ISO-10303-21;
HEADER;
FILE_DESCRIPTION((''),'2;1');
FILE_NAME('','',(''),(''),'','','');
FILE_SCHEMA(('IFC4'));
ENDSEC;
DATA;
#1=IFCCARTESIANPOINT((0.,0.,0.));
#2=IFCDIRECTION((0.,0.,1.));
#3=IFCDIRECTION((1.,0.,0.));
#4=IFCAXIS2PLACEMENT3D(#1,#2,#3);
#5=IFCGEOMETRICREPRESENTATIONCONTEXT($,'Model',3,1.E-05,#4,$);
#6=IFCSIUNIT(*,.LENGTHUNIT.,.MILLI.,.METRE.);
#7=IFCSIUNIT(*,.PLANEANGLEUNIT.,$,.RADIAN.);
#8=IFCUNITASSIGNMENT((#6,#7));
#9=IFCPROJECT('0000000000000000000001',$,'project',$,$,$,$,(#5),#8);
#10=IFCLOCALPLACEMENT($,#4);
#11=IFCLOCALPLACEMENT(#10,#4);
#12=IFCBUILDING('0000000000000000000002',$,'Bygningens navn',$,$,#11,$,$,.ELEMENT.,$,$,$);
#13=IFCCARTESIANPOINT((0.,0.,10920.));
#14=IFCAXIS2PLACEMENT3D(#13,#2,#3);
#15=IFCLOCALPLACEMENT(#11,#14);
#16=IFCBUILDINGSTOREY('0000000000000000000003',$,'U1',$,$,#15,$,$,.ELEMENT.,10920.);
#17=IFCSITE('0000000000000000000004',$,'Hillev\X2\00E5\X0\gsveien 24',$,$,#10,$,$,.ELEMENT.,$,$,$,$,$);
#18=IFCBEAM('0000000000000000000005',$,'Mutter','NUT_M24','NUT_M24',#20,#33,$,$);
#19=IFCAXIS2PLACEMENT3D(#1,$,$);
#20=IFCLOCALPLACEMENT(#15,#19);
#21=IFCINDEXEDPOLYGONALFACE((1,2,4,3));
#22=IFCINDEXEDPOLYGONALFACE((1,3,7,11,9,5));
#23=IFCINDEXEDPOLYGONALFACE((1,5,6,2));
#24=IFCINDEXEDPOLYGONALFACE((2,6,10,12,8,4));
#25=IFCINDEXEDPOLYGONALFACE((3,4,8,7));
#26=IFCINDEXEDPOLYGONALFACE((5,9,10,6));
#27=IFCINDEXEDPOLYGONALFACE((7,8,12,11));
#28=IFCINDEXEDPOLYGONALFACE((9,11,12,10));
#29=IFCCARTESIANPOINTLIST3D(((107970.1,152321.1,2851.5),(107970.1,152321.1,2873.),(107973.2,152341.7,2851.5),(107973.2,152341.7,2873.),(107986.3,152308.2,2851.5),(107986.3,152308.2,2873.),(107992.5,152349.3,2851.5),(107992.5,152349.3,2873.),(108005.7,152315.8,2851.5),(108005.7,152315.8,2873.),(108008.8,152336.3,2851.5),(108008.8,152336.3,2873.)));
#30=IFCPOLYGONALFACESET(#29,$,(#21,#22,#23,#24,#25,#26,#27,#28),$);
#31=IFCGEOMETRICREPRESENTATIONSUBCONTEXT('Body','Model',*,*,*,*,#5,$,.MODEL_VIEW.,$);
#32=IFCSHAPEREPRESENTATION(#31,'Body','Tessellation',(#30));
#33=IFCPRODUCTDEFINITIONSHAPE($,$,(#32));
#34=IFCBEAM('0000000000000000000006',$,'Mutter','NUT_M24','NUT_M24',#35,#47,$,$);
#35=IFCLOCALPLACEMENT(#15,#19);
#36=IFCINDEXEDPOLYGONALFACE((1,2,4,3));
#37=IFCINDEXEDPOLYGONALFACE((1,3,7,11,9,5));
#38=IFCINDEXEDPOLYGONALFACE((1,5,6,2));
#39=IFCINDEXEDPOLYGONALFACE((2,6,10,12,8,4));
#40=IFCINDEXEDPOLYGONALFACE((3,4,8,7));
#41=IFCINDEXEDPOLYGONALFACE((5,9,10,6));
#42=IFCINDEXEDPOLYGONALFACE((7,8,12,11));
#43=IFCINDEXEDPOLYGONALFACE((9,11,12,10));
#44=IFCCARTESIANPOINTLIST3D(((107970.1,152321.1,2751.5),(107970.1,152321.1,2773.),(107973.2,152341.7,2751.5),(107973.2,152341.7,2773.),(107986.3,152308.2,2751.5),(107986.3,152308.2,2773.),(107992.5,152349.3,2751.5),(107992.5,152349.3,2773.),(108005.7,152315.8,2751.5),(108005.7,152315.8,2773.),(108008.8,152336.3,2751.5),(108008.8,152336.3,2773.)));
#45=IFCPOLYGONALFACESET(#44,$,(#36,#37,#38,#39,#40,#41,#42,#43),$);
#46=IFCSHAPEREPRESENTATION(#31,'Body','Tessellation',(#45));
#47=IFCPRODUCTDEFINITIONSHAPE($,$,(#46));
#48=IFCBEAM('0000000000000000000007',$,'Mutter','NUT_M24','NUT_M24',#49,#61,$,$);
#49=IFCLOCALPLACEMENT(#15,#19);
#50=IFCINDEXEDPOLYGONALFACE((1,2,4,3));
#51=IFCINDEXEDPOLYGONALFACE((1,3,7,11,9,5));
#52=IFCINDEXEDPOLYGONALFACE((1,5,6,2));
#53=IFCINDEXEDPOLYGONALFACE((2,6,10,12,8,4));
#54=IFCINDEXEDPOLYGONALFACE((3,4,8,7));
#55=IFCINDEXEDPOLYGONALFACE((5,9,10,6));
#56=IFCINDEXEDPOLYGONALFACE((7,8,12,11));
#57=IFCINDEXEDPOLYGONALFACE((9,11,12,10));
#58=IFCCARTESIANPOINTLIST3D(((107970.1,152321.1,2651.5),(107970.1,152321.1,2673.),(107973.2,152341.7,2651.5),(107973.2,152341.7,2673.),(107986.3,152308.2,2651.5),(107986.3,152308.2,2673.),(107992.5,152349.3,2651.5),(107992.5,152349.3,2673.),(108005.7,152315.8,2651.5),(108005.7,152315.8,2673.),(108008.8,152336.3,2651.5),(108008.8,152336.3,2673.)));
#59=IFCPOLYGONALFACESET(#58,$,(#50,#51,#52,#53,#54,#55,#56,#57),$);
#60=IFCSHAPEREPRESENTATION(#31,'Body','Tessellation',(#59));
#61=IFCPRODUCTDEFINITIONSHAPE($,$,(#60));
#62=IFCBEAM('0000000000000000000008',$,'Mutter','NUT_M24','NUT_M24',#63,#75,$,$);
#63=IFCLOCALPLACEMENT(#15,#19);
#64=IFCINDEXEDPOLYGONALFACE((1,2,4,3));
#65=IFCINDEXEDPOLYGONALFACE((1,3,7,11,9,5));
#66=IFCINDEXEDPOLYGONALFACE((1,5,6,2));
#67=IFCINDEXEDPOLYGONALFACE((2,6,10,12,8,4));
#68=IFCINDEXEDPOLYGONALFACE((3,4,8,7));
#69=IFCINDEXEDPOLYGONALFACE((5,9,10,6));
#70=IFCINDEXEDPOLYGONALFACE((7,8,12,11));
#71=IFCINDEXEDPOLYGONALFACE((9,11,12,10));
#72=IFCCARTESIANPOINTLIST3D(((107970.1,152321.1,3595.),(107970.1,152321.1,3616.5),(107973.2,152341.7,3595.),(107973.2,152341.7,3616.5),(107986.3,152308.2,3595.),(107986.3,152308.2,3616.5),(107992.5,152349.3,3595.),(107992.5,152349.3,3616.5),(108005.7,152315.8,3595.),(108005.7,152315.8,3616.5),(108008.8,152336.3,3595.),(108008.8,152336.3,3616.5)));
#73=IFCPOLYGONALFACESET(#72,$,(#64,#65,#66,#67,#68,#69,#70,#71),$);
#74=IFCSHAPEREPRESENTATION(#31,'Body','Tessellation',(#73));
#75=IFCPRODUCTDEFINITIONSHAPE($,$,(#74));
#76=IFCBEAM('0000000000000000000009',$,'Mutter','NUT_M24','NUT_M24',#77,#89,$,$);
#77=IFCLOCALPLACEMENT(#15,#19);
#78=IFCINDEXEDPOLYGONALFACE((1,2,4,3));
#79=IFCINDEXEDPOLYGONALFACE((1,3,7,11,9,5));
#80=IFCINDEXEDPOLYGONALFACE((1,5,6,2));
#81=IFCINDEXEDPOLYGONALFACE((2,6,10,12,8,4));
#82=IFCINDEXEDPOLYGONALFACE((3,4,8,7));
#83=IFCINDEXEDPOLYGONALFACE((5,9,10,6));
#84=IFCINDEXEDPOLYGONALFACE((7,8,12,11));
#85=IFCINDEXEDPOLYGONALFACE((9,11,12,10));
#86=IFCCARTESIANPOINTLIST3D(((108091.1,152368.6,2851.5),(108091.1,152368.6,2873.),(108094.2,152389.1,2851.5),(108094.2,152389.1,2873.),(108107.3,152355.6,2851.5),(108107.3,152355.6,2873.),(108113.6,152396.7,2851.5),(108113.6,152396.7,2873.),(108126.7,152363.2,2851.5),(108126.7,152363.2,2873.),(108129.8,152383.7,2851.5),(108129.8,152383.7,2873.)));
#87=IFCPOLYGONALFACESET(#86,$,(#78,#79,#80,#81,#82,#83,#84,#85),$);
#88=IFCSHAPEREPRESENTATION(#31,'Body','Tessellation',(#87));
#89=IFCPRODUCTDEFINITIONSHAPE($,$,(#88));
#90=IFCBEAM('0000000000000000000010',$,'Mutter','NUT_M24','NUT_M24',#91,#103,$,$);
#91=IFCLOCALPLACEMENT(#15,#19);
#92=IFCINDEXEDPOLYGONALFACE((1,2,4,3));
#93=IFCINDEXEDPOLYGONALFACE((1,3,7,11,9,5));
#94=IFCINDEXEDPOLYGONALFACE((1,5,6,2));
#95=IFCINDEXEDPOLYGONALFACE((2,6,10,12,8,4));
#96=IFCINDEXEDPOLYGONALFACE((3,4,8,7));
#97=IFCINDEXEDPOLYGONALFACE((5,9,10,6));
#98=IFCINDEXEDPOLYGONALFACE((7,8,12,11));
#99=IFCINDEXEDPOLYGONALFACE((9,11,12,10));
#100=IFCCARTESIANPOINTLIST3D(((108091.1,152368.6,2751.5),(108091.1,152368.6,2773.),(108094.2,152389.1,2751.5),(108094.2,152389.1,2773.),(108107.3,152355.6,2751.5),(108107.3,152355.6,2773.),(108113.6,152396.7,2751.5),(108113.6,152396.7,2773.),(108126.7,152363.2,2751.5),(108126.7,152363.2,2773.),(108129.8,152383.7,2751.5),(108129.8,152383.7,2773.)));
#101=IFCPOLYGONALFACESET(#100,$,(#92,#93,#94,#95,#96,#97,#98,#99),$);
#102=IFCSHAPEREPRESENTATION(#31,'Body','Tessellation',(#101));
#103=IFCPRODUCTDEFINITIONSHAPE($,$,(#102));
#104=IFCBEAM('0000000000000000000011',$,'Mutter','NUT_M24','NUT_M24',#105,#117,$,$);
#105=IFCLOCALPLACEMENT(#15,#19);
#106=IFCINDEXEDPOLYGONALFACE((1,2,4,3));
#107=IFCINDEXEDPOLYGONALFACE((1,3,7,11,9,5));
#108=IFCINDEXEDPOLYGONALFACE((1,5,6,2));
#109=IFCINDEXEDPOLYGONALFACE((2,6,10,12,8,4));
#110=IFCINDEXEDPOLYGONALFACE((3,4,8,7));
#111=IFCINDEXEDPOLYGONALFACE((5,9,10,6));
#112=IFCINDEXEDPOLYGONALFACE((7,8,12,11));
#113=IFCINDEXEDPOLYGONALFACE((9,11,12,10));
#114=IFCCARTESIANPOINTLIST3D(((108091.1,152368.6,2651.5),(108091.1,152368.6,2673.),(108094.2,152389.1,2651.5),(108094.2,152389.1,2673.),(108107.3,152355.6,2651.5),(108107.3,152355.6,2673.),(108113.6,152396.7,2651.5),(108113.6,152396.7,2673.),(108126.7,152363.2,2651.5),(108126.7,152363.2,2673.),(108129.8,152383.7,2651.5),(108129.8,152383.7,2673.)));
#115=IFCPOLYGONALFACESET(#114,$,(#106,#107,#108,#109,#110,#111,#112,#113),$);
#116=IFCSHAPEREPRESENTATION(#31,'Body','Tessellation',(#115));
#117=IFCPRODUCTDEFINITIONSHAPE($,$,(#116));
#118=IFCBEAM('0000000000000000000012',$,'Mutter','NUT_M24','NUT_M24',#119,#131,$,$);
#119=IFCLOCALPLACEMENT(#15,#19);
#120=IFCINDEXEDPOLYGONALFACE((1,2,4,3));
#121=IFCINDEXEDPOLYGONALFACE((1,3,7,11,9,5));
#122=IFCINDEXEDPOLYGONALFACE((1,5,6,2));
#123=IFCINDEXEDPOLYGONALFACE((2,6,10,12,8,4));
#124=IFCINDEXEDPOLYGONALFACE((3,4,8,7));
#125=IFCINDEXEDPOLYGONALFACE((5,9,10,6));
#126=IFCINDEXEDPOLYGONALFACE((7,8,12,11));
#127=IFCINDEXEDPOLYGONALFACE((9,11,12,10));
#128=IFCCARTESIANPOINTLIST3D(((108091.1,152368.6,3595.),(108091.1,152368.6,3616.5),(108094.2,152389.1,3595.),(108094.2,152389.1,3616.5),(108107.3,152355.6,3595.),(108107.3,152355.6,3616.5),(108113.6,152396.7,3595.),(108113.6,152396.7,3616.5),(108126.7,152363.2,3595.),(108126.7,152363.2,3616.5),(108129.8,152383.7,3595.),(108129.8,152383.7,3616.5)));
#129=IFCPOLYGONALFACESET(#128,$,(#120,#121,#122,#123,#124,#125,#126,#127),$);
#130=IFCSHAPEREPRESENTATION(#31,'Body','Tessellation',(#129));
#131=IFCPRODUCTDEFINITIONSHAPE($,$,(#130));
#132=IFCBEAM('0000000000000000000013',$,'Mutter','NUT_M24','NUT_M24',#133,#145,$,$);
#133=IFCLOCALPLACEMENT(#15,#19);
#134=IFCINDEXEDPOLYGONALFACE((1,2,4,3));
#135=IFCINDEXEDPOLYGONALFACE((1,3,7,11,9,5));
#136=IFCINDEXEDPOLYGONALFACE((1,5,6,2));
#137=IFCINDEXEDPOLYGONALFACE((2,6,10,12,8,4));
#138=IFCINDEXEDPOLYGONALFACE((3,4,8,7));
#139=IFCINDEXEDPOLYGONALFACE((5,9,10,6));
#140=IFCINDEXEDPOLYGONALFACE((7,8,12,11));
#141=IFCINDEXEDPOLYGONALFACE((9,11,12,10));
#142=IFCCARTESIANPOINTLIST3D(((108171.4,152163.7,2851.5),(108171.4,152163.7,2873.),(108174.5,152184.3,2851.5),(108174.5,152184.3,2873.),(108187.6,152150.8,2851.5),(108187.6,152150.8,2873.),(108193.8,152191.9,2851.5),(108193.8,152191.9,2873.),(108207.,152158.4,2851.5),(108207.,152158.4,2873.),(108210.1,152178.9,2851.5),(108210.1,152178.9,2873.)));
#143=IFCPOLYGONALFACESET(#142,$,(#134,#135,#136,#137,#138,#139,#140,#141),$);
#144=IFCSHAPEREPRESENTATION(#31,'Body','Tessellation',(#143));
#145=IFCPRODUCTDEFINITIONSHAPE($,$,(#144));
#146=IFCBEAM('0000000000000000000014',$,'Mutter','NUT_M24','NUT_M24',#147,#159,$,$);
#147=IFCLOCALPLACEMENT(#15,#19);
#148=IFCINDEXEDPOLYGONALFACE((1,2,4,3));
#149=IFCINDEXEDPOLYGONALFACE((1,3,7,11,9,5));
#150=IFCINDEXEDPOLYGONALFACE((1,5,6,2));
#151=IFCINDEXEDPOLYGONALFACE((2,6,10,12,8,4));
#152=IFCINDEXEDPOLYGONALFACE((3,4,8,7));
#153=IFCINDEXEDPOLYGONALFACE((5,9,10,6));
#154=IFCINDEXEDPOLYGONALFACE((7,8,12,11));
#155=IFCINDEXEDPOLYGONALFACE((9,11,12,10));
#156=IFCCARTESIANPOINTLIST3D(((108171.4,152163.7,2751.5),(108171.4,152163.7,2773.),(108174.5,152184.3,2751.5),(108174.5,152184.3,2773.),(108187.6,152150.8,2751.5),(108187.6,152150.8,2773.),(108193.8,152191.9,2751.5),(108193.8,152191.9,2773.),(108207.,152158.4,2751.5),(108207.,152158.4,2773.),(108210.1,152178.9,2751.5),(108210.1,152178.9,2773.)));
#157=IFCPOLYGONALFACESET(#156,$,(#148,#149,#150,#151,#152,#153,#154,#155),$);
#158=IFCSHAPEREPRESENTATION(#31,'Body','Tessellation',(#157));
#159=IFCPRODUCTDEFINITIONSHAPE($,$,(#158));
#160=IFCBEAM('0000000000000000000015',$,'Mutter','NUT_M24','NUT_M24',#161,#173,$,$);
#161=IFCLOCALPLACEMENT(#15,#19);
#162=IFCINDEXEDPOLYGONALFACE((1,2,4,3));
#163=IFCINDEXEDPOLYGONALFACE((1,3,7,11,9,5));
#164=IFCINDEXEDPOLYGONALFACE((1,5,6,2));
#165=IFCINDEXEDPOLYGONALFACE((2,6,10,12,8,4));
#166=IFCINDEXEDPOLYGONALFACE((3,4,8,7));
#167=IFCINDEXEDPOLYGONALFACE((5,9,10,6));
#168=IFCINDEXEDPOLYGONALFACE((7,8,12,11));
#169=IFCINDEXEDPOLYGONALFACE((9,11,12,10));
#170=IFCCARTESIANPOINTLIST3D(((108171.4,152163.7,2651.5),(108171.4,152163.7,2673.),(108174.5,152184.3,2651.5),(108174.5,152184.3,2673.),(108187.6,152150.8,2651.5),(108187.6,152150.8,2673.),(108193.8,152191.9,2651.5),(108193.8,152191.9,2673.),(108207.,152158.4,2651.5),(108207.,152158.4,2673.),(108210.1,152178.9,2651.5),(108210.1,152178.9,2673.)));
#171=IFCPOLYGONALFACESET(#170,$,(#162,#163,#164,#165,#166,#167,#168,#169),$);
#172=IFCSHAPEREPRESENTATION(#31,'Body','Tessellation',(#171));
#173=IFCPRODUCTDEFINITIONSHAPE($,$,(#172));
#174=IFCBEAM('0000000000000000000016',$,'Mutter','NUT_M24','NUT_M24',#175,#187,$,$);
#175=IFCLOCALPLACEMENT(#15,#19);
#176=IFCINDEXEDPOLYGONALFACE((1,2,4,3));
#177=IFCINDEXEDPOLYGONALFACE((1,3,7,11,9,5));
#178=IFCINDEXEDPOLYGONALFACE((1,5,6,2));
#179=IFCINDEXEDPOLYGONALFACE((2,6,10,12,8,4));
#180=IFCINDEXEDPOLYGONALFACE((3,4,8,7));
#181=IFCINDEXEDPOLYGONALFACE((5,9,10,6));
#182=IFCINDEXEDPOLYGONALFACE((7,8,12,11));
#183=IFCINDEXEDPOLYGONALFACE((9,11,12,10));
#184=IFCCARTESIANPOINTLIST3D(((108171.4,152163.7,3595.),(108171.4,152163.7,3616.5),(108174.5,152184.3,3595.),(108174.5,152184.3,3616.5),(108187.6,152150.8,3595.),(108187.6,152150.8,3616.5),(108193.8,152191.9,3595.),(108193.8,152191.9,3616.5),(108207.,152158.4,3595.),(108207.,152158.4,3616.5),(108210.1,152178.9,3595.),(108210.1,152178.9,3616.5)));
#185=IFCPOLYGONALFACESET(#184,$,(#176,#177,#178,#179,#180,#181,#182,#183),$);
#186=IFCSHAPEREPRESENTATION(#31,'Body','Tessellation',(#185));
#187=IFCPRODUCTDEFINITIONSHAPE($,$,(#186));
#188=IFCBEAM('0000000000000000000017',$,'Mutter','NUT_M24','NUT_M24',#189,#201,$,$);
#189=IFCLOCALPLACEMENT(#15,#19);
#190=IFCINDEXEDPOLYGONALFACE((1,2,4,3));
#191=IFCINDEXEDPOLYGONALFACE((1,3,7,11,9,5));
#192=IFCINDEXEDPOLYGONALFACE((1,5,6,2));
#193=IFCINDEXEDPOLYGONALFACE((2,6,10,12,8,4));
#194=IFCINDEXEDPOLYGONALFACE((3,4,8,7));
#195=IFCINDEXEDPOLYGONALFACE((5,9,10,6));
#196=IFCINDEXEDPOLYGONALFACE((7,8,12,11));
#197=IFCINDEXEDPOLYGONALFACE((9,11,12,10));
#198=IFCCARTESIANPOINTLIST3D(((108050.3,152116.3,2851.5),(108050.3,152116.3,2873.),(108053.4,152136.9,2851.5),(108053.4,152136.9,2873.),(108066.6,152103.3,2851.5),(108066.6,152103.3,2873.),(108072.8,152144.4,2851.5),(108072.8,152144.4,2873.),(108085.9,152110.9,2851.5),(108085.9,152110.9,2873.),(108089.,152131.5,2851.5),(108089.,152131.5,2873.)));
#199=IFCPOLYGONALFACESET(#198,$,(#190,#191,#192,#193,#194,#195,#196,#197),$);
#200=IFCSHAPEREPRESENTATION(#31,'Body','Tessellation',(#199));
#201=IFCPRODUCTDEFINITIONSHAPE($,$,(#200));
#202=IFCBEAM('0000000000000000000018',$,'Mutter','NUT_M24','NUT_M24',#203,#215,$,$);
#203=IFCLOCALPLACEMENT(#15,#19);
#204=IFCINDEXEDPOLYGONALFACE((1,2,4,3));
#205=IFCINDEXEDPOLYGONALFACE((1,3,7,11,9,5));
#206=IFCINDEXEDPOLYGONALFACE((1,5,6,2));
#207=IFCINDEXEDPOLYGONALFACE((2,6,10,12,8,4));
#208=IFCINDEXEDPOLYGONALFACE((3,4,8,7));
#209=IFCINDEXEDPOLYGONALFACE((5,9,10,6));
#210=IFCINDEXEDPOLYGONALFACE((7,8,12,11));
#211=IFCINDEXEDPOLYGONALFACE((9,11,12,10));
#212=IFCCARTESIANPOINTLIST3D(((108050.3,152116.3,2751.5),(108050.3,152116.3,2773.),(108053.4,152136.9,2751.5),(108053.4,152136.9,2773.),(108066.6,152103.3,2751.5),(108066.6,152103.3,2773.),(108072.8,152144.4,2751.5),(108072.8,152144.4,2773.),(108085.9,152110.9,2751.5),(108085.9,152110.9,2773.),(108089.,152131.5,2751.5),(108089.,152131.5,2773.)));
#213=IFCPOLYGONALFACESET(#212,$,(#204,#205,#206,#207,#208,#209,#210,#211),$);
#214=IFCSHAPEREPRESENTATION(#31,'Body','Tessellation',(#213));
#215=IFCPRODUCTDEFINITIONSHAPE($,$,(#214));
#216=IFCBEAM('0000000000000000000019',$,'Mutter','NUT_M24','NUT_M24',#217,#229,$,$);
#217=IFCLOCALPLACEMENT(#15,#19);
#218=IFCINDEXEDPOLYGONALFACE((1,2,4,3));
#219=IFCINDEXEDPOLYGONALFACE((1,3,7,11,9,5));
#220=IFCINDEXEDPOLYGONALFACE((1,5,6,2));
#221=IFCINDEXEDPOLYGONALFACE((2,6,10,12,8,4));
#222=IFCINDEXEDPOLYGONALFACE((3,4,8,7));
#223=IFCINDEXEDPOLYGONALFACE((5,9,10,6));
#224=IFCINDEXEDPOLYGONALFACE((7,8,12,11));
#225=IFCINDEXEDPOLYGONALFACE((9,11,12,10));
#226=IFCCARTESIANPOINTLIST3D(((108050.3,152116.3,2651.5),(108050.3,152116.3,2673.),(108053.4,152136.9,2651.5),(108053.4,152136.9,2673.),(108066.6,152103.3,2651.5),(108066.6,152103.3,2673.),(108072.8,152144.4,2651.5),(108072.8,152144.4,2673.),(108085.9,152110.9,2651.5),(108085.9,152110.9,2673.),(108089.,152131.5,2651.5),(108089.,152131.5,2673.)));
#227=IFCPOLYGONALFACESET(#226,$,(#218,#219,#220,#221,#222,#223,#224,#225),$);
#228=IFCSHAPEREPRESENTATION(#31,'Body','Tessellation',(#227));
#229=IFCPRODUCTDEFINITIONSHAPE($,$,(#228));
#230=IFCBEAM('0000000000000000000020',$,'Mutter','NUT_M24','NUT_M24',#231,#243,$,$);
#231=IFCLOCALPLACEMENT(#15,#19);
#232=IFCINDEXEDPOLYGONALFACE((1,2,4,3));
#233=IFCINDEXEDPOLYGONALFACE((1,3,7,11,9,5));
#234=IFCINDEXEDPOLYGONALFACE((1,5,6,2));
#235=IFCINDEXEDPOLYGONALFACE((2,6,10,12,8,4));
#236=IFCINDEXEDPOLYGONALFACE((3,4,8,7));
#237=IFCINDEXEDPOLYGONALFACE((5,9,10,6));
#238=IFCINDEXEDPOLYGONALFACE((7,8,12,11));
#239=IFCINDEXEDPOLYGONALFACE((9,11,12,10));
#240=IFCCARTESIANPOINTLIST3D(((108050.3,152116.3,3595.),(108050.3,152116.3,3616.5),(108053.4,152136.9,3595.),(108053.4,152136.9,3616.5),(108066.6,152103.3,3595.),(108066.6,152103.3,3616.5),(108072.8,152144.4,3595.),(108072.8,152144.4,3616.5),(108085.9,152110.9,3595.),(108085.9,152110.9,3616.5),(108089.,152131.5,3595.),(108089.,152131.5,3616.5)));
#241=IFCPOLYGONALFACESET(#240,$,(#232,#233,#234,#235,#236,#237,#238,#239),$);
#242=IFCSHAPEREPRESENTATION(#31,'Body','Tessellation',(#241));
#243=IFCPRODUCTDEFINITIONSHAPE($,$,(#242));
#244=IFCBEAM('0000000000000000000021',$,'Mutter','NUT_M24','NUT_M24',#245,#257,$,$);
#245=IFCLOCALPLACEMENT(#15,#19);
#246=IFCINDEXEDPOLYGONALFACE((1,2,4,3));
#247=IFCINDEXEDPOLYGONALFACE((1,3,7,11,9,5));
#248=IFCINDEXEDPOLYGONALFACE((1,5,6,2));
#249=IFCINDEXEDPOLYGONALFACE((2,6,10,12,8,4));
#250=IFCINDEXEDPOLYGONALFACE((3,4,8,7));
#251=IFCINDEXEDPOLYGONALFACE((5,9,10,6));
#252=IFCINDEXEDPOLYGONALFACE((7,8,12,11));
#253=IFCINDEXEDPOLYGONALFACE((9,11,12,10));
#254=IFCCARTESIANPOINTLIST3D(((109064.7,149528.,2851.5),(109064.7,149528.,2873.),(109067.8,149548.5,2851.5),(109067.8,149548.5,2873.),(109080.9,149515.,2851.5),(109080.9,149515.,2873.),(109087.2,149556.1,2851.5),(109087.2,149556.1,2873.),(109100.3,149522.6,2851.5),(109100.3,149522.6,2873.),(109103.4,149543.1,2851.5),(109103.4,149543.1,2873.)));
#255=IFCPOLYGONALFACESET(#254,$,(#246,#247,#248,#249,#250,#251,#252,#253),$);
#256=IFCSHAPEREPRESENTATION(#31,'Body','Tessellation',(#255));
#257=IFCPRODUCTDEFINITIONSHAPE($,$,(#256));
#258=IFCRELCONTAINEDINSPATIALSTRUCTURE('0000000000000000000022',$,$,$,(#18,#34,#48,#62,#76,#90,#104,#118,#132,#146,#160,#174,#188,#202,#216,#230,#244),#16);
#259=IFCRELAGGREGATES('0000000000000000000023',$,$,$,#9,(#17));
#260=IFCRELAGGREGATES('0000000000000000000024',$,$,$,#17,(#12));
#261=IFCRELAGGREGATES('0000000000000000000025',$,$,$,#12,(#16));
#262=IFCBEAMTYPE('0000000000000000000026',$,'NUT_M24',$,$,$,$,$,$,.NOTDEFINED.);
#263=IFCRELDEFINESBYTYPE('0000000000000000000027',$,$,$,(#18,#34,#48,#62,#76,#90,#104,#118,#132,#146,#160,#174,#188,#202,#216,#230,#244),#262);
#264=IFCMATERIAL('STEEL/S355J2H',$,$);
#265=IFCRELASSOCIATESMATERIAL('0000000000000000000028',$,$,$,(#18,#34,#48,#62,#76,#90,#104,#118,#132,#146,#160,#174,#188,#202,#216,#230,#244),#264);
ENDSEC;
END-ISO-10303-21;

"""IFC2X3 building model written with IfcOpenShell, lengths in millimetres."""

from ifc_helpers import new_model, si_unit, frame, origin_with_axes, place, context, subcontext, project, spatial, polyline, outline, extrude, material, type_object, element, save


model = new_model("IFC2X3")

# Units and contexts
model_context = context("Model", 3, precision=1e-05, world=origin_with_axes())
body_context = subcontext(model_context, "Body", "Model", "MODEL_VIEW")
ifc_project = project(units=[si_unit("LENGTHUNIT", "METRE", prefix="MILLI"), si_unit("PLANEANGLEUNIT", "RADIAN")], contexts=[model_context])

# Site, building, storey
site_placement = place(None, origin_with_axes())
site = spatial("IfcSite", under=ifc_project, at=site_placement, Name="Hillevågsveien 24", CompositionType="ELEMENT")
building_placement = place(site_placement, origin_with_axes())
building = spatial("IfcBuilding", under=site, at=building_placement, Name="Bygningens navn", CompositionType="ELEMENT")
storey_placement = place(building_placement, frame((0.0, 0.0, 10920.0), z_axis=(0.0, 0.0, 1.0), x_axis=(1.0, 0.0, 0.0)))
storey = spatial("IfcBuildingStorey", under=building, at=storey_placement, Name="U1", CompositionType="ELEMENT", Elevation=10920.0)

# Beams
ifc_material = material(Name="STEEL/S355J2H")
beam_type_1 = type_object("IfcBeamType", Name="NUT_M24", PredefinedType="NOTDEFINED")
for number, where, z_axis, x_axis, name in (
    (1, (107989.4, 152328.7, 2873.0), (-0.364877, 0.931056, 0.0), (0.0, 0.0, -1.0), "Mutter"),
    (2, (107989.4, 152328.7, 2773.0), (-0.364877, 0.931056, 0.0), (0.0, 0.0, -1.0), "Mutter"),
    (3, (107989.4, 152328.7, 2673.0), (-0.364877, 0.931056, 0.0), (0.0, 0.0, -1.0), "Mutter"),
    (4, (107989.4, 152328.7, 3616.5), (-0.364877, 0.931056, 0.0), (0.0, 0.0, -1.0), "Mutter"),
    (5, (108110.4, 152376.2, 2873.0), (-0.364877, 0.931056, 0.0), (0.0, 0.0, -1.0), "Mutter"),
    (6, (108110.4, 152376.2, 2773.0), (-0.364877, 0.931056, 0.0), (0.0, 0.0, -1.0), "Mutter"),
    (7, (108110.4, 152376.2, 2673.0), (-0.364877, 0.931056, 0.0), (0.0, 0.0, -1.0), "Mutter"),
    (8, (108110.4, 152376.2, 3616.5), (-0.364877, 0.931056, 0.0), (0.0, 0.0, -1.0), "Mutter"),
    (9, (108190.7, 152171.3, 2873.0), (-0.364877, 0.931056, 0.0), (0.0, 0.0, -1.0), "Mutter"),
    (10, (108190.7, 152171.3, 2773.0), (-0.364877, 0.931056, 0.0), (0.0, 0.0, -1.0), "Mutter"),
    (11, (108190.7, 152171.3, 2673.0), (-0.364877, 0.931056, 0.0), (0.0, 0.0, -1.0), "Mutter"),
    (12, (108190.7, 152171.3, 3616.5), (-0.364877, 0.931056, 0.0), (0.0, 0.0, -1.0), "Mutter"),
    (13, (108069.7, 152123.9, 2873.0), (-0.364877, 0.931056, 0.0), (0.0, 0.0, -1.0), "Mutter"),
    (14, (108069.7, 152123.9, 2773.0), (-0.364877, 0.931056, 0.0), (0.0, 0.0, -1.0), "Mutter"),
    (15, (108069.7, 152123.9, 2673.0), (-0.364877, 0.931056, 0.0), (0.0, 0.0, -1.0), "Mutter"),
    (16, (108069.7, 152123.9, 3616.5), (-0.364877, 0.931056, 0.0), (0.0, 0.0, -1.0), "Mutter"),
    (17, (109084.0, 149535.6, 2873.0), (-0.364877, 0.931056, 0.0), (0.0, 0.0, -1.0), "Mutter"),
):
    element("IfcBeam", number, at=place(storey_placement, frame(where, z_axis=z_axis, x_axis=x_axis)), inside=storey, type_object=beam_type_1, material=ifc_material, Name=name, Description="NUT_M24", ObjectType="NUT_M24", context=body_context, shape_type="SweptSolid", body=[
        extrude(outline(polyline([(-10.4, 18.0), (10.4, 18.0), (20.8, 0.0), (10.4, -18.0), (-10.4, -18.0), (-20.8, 0.0), (-10.4, 18.0)])), frame((21.5, 0.0, 0.0), z_axis=(-1.0, 0.0, 0.0), x_axis=(0.0, -1.0, 0.0)), (0.0, 0.0, 1.0), 21.5),
    ])

save(model, "model.ifc")
